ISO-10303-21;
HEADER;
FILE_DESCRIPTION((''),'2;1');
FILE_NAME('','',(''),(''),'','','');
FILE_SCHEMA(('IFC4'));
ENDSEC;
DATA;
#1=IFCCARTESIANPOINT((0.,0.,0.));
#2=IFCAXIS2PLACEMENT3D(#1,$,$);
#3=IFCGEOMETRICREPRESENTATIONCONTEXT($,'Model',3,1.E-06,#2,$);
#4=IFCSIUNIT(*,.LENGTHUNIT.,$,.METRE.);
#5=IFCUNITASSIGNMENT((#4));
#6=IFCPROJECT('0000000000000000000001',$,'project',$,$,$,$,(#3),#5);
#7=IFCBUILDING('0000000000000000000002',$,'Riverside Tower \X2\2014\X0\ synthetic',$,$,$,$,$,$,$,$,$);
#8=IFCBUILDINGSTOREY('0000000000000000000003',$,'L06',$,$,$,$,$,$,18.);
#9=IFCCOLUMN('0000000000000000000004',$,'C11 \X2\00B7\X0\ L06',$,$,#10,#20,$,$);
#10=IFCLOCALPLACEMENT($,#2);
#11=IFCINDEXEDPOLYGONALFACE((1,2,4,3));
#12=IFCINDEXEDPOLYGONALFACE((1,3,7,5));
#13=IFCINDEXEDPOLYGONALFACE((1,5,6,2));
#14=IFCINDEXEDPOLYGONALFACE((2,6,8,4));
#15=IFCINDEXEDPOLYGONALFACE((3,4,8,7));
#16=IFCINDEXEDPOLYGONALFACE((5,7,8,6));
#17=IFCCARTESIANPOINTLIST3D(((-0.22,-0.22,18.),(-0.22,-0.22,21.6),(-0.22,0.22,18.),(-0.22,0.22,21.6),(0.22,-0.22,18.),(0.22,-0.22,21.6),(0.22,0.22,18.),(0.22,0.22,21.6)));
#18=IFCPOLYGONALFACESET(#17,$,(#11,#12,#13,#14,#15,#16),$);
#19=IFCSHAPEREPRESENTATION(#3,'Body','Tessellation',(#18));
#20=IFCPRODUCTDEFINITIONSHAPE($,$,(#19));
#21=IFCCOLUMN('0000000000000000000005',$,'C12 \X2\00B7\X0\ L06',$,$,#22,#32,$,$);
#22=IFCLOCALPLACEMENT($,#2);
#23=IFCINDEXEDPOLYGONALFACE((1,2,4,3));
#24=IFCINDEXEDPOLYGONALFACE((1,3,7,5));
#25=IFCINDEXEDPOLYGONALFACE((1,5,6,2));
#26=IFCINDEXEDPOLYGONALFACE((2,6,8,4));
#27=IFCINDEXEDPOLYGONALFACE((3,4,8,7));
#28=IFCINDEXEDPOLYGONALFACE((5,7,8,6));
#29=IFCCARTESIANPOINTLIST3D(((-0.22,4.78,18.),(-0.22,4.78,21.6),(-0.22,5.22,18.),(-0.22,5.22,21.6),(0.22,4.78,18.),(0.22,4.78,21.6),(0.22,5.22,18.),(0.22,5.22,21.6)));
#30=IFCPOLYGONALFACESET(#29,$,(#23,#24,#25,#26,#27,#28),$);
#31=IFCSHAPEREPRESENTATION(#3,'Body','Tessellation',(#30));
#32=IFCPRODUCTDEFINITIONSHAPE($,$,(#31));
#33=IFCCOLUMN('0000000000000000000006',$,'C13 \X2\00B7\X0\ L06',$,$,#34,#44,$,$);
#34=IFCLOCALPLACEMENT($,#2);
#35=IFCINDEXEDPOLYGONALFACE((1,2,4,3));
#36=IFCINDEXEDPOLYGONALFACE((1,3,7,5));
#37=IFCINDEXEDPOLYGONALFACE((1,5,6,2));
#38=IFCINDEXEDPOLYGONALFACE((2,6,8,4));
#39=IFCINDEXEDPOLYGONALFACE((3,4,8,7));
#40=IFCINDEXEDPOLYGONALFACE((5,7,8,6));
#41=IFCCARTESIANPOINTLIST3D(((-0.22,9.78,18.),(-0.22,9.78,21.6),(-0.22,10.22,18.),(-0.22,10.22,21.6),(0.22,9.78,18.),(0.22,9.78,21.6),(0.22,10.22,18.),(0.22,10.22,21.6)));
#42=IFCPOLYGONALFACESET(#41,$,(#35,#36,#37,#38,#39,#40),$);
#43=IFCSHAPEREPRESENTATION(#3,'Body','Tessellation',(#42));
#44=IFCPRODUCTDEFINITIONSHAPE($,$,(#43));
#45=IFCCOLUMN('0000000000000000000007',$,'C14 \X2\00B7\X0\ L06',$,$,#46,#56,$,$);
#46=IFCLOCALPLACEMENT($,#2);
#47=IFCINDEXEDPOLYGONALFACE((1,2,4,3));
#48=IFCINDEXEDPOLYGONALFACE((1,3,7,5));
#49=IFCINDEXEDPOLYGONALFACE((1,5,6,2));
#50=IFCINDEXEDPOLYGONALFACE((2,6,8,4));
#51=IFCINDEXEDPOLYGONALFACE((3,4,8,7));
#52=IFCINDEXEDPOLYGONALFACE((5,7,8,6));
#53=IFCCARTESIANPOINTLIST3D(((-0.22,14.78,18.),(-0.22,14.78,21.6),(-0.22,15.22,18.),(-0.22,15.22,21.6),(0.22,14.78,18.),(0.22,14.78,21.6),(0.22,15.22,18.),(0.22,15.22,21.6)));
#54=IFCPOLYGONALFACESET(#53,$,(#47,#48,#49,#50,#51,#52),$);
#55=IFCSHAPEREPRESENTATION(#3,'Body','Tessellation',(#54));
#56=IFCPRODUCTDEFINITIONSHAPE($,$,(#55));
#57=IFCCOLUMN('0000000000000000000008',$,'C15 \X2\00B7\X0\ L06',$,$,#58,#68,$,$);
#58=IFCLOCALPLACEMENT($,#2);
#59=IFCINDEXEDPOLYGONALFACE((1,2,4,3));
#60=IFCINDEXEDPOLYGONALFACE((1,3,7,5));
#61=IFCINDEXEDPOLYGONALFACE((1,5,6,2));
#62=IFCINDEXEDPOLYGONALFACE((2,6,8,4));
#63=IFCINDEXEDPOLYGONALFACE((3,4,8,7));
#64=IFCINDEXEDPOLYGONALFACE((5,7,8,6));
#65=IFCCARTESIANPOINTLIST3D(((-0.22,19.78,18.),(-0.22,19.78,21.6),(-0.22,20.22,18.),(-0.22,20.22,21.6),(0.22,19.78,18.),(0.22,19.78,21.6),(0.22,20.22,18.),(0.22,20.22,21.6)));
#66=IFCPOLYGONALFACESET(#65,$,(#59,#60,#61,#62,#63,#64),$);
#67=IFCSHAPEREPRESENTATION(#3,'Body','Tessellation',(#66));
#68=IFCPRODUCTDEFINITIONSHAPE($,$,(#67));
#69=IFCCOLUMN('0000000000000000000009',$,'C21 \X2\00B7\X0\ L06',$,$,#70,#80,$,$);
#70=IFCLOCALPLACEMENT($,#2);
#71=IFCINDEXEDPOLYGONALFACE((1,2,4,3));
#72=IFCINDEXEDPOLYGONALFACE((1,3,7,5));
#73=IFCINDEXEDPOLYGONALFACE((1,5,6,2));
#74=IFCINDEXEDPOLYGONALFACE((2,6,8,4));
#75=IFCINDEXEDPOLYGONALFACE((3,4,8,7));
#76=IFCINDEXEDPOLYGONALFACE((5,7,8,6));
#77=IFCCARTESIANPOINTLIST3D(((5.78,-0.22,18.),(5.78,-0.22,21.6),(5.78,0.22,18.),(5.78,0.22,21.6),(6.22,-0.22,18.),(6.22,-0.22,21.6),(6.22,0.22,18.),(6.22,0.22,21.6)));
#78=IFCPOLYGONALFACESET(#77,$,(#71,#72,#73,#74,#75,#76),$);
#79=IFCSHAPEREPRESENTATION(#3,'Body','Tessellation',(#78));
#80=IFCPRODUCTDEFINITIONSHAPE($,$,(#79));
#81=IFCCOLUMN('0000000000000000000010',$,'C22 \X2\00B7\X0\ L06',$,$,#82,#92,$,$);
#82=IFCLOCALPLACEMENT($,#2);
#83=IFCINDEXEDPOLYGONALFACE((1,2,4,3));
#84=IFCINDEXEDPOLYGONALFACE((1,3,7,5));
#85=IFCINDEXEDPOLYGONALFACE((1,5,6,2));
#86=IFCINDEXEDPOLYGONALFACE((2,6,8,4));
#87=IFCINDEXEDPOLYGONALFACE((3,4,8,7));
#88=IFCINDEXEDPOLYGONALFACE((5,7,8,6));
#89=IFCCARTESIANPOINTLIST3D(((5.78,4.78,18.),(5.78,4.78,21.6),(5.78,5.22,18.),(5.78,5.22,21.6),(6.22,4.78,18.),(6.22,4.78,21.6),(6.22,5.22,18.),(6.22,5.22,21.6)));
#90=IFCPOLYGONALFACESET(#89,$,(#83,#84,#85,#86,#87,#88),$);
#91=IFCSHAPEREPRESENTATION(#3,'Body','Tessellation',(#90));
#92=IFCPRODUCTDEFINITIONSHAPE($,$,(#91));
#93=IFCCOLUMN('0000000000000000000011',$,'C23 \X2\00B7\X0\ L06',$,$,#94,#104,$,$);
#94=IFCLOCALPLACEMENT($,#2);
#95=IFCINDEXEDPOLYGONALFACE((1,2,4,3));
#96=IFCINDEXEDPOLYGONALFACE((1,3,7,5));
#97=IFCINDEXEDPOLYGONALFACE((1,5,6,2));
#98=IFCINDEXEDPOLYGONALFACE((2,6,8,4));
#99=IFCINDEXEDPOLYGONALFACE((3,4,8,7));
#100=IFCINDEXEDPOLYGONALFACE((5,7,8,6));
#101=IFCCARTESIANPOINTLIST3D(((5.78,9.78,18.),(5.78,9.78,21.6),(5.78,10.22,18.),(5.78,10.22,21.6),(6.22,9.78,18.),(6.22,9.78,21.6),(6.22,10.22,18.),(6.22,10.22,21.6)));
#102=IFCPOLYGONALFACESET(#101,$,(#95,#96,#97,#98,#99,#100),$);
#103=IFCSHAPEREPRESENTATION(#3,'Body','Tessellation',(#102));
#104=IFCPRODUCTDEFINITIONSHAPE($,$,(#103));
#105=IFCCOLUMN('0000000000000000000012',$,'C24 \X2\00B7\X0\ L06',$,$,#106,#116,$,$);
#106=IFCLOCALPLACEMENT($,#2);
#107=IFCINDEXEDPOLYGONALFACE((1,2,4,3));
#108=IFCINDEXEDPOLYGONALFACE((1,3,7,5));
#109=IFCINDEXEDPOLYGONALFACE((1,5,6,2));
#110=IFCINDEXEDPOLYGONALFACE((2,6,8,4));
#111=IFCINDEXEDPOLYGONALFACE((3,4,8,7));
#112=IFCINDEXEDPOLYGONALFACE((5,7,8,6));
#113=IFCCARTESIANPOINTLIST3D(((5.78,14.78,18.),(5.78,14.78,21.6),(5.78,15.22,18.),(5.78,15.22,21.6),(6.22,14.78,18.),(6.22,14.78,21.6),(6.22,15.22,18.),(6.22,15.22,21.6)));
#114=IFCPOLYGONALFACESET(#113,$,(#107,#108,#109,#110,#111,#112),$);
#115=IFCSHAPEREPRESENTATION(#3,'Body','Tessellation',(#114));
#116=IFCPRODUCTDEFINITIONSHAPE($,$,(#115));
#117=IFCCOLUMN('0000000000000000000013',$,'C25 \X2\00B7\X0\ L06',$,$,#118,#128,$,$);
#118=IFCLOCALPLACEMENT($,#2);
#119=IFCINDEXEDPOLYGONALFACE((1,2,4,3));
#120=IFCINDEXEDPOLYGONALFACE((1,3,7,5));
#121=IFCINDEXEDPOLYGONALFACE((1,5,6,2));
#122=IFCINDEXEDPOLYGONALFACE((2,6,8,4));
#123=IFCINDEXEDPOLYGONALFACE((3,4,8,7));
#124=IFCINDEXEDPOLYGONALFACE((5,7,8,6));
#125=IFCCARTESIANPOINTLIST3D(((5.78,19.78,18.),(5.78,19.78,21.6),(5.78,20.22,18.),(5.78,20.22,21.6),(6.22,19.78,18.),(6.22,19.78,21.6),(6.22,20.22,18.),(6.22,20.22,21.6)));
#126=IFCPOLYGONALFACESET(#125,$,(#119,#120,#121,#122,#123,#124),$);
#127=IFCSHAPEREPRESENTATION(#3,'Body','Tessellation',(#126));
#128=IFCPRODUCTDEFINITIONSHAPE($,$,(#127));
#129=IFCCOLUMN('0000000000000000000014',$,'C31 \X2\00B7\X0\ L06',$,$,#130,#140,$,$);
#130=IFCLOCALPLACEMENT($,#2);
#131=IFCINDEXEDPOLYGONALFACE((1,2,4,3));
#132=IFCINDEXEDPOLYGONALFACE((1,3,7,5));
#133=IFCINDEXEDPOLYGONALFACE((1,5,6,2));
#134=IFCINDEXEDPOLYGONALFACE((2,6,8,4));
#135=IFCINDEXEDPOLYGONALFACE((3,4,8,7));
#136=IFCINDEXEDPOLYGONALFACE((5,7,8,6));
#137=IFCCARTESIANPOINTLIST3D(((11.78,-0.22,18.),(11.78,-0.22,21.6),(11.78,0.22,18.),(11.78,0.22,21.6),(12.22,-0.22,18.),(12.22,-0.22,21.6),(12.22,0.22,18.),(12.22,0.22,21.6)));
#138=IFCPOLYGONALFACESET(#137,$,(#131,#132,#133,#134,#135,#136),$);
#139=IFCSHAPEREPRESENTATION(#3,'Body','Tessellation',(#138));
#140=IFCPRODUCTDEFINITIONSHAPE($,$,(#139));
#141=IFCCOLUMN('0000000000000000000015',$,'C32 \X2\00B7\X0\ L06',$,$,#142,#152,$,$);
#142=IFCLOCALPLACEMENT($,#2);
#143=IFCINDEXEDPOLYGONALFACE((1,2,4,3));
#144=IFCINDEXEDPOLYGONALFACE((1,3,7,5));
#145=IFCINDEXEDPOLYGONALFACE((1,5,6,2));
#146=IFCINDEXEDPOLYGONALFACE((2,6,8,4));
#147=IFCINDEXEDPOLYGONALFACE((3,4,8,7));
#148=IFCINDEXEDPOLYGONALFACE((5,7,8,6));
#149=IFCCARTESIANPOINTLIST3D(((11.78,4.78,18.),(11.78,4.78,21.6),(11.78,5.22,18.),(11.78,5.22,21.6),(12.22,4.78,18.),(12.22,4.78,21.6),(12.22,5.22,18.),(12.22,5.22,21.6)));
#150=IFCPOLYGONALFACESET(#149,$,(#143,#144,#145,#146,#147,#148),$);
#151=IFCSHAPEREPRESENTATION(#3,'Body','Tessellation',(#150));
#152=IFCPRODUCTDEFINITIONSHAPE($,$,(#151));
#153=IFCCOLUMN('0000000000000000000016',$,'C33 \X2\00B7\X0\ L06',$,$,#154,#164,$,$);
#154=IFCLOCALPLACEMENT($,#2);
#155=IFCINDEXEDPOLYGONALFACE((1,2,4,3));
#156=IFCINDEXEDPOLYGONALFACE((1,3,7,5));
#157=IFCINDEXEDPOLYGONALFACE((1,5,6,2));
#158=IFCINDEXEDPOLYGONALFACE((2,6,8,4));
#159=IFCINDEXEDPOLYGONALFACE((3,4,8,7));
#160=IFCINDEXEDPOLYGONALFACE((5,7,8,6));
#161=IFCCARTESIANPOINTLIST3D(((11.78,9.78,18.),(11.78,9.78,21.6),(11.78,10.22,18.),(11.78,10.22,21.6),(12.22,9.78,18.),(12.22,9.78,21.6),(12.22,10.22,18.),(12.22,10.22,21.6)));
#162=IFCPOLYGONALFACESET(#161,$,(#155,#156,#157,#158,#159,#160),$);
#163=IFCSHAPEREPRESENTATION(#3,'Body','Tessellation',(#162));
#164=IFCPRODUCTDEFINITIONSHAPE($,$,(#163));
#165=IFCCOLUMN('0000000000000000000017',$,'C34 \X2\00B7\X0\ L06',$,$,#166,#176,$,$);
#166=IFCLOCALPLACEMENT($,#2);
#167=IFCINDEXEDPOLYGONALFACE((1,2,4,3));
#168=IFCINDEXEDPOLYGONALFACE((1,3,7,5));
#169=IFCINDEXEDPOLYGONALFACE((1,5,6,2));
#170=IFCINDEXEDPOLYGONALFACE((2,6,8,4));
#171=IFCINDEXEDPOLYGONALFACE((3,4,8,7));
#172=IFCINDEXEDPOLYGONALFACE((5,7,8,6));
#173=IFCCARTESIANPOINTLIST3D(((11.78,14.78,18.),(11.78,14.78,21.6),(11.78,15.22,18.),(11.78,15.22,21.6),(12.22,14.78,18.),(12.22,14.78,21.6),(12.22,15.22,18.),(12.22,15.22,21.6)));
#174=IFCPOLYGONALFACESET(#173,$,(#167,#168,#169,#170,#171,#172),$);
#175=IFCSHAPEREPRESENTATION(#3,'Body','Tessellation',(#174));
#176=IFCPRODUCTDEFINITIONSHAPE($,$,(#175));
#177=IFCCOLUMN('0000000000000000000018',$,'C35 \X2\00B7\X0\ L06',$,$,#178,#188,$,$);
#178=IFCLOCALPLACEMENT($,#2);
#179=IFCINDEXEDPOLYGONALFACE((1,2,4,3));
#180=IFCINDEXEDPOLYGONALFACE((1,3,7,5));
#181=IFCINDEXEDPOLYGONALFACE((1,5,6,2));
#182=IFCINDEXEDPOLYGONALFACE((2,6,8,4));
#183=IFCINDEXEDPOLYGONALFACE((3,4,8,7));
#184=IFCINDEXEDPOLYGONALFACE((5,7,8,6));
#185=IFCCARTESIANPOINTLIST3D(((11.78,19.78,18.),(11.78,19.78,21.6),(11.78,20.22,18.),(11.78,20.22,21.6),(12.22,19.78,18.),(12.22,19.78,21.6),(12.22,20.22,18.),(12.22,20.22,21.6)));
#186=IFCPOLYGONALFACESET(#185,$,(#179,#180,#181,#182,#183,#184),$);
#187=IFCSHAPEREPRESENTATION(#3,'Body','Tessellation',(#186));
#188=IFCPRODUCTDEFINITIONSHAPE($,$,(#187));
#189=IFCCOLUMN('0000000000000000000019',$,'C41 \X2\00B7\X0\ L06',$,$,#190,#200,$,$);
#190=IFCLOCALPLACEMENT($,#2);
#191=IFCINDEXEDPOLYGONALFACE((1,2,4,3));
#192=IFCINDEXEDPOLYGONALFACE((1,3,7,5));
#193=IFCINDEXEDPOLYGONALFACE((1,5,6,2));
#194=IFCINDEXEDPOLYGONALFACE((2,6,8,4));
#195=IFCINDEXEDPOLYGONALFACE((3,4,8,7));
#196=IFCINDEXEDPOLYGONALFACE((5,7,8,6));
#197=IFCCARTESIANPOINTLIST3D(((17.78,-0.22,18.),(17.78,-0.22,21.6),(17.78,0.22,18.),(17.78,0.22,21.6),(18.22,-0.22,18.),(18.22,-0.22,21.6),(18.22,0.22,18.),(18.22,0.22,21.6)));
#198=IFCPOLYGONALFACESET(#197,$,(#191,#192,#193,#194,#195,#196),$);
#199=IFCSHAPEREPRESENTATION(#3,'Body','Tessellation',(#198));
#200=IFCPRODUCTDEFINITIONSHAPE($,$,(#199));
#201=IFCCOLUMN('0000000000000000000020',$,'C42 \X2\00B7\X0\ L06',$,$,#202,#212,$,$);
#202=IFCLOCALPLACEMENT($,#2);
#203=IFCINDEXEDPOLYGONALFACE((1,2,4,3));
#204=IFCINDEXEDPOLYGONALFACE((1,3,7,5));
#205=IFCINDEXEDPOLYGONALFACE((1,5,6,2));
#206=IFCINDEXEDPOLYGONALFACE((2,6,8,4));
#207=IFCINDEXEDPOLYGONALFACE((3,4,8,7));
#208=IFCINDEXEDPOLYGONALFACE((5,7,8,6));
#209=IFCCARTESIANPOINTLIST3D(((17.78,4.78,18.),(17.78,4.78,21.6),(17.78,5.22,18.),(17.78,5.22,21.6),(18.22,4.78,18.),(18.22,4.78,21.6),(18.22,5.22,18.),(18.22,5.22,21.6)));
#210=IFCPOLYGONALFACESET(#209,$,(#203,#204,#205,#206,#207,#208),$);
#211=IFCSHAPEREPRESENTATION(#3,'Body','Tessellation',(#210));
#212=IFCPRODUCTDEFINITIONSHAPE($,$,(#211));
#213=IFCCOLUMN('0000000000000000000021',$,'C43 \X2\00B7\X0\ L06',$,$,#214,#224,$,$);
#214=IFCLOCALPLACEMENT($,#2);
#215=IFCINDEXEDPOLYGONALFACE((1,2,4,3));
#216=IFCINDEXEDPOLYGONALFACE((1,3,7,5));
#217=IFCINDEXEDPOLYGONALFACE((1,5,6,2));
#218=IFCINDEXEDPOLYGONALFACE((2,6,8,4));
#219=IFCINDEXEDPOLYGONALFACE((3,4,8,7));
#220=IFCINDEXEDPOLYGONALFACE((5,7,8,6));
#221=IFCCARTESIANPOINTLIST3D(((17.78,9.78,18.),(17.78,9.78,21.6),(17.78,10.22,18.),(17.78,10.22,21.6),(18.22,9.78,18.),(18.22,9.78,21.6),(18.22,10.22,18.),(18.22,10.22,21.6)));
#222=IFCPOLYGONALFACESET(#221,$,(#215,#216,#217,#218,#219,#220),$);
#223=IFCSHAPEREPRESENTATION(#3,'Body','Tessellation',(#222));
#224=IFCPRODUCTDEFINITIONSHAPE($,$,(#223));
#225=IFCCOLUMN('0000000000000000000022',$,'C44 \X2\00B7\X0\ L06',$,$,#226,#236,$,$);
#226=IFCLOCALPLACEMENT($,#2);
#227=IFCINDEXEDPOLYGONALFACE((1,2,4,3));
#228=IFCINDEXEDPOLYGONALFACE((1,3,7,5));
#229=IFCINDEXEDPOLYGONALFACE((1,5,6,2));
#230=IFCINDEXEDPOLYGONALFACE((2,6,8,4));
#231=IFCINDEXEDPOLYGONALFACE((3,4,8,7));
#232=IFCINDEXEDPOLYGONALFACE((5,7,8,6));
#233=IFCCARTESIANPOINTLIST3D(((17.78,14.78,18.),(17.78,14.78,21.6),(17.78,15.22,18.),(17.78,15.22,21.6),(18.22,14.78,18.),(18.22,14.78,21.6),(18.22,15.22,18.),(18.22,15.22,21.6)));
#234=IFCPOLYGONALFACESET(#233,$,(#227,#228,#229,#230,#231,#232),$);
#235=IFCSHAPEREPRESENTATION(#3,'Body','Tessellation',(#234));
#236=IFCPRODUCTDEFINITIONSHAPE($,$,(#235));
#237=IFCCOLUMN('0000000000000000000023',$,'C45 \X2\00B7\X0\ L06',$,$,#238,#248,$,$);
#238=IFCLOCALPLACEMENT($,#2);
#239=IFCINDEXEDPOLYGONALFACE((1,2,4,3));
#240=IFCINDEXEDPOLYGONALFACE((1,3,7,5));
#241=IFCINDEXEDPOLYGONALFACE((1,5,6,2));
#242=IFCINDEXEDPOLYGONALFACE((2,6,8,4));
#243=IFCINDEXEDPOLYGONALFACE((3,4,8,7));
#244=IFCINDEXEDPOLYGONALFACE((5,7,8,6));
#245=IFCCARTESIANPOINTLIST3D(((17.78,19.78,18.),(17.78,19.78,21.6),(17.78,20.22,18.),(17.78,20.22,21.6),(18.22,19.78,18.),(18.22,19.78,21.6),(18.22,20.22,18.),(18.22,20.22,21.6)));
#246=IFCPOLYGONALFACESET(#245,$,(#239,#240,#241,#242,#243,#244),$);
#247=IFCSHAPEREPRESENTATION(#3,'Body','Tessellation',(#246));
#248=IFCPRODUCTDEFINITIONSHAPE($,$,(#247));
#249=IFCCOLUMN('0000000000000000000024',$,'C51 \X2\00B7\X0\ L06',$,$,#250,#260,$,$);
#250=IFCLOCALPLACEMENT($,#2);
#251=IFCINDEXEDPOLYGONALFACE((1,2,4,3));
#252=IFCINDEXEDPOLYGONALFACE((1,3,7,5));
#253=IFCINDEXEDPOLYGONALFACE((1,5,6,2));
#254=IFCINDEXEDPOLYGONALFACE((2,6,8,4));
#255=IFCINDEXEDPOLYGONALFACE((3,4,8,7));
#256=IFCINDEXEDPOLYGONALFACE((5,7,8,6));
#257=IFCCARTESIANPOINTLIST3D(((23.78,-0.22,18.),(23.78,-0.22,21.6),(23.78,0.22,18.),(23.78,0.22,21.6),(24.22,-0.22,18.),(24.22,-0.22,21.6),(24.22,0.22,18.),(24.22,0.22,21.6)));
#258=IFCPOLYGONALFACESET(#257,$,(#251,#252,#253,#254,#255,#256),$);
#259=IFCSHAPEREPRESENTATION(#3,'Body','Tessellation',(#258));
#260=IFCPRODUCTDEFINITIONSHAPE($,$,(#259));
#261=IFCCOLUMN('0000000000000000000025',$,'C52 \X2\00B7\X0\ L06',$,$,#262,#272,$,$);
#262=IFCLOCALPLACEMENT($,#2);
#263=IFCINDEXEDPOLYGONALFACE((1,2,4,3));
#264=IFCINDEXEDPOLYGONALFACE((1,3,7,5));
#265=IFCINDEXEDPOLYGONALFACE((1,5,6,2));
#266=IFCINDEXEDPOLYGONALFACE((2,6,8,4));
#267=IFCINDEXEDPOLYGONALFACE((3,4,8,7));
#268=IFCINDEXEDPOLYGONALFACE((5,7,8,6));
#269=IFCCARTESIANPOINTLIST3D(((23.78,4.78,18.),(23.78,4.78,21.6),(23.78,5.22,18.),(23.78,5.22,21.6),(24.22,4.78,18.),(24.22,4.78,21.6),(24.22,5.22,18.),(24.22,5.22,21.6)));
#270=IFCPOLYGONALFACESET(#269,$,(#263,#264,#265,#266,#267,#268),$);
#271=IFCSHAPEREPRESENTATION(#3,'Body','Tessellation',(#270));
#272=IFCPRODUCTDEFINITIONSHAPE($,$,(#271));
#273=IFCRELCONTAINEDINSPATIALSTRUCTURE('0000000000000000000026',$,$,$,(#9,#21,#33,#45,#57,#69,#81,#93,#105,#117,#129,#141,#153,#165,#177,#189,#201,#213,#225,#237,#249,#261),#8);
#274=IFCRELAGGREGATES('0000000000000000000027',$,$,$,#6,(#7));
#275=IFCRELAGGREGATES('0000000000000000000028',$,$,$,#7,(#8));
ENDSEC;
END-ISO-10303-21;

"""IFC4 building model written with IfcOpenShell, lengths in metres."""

from ifc_helpers import new_model, si_unit, frame, origin, place, context, project, spatial, rectangle, extrude, element, save


model = new_model("IFC4")

# Units and contexts
model_context = context("Model", 3, precision=1e-06, world=origin())
ifc_project = project(units=[si_unit("LENGTHUNIT", "METRE")], contexts=[model_context])

# Building, storey
building = spatial("IfcBuilding", under=ifc_project, Name="Riverside Tower — synthetic")
storey = spatial("IfcBuildingStorey", under=building, Name="L06", Elevation=18.0)

# Columns
for number, where, name in (
    (1, (0.0, 0.0, 18.0), "C11 · L06"),
    (2, (0.0, 5.0, 18.0), "C12 · L06"),
    (3, (0.0, 10.0, 18.0), "C13 · L06"),
    (4, (0.0, 15.0, 18.0), "C14 · L06"),
    (5, (0.0, 20.0, 18.0), "C15 · L06"),
    (6, (6.0, 0.0, 18.0), "C21 · L06"),
    (7, (6.0, 5.0, 18.0), "C22 · L06"),
    (8, (6.0, 10.0, 18.0), "C23 · L06"),
    (9, (6.0, 15.0, 18.0), "C24 · L06"),
    (10, (6.0, 20.0, 18.0), "C25 · L06"),
    (11, (12.0, 0.0, 18.0), "C31 · L06"),
    (12, (12.0, 5.0, 18.0), "C32 · L06"),
    (13, (12.0, 10.0, 18.0), "C33 · L06"),
    (14, (12.0, 15.0, 18.0), "C34 · L06"),
    (15, (12.0, 20.0, 18.0), "C35 · L06"),
    (16, (18.0, 0.0, 18.0), "C41 · L06"),
    (17, (18.0, 5.0, 18.0), "C42 · L06"),
    (18, (18.0, 10.0, 18.0), "C43 · L06"),
    (19, (18.0, 15.0, 18.0), "C44 · L06"),
    (20, (18.0, 20.0, 18.0), "C45 · L06"),
    (21, (24.0, 0.0, 18.0), "C51 · L06"),
    (22, (24.0, 5.0, 18.0), "C52 · L06"),
):
    element("IfcColumn", number, at=place(None, frame(where)), inside=storey, Name=name, context=model_context, shape_type="SweptSolid", body=[
        extrude(rectangle(XDim=0.44, YDim=0.44), origin(), (0.0, 0.0, 1.0), 3.6),
    ])

save(model, "model.ifc")
